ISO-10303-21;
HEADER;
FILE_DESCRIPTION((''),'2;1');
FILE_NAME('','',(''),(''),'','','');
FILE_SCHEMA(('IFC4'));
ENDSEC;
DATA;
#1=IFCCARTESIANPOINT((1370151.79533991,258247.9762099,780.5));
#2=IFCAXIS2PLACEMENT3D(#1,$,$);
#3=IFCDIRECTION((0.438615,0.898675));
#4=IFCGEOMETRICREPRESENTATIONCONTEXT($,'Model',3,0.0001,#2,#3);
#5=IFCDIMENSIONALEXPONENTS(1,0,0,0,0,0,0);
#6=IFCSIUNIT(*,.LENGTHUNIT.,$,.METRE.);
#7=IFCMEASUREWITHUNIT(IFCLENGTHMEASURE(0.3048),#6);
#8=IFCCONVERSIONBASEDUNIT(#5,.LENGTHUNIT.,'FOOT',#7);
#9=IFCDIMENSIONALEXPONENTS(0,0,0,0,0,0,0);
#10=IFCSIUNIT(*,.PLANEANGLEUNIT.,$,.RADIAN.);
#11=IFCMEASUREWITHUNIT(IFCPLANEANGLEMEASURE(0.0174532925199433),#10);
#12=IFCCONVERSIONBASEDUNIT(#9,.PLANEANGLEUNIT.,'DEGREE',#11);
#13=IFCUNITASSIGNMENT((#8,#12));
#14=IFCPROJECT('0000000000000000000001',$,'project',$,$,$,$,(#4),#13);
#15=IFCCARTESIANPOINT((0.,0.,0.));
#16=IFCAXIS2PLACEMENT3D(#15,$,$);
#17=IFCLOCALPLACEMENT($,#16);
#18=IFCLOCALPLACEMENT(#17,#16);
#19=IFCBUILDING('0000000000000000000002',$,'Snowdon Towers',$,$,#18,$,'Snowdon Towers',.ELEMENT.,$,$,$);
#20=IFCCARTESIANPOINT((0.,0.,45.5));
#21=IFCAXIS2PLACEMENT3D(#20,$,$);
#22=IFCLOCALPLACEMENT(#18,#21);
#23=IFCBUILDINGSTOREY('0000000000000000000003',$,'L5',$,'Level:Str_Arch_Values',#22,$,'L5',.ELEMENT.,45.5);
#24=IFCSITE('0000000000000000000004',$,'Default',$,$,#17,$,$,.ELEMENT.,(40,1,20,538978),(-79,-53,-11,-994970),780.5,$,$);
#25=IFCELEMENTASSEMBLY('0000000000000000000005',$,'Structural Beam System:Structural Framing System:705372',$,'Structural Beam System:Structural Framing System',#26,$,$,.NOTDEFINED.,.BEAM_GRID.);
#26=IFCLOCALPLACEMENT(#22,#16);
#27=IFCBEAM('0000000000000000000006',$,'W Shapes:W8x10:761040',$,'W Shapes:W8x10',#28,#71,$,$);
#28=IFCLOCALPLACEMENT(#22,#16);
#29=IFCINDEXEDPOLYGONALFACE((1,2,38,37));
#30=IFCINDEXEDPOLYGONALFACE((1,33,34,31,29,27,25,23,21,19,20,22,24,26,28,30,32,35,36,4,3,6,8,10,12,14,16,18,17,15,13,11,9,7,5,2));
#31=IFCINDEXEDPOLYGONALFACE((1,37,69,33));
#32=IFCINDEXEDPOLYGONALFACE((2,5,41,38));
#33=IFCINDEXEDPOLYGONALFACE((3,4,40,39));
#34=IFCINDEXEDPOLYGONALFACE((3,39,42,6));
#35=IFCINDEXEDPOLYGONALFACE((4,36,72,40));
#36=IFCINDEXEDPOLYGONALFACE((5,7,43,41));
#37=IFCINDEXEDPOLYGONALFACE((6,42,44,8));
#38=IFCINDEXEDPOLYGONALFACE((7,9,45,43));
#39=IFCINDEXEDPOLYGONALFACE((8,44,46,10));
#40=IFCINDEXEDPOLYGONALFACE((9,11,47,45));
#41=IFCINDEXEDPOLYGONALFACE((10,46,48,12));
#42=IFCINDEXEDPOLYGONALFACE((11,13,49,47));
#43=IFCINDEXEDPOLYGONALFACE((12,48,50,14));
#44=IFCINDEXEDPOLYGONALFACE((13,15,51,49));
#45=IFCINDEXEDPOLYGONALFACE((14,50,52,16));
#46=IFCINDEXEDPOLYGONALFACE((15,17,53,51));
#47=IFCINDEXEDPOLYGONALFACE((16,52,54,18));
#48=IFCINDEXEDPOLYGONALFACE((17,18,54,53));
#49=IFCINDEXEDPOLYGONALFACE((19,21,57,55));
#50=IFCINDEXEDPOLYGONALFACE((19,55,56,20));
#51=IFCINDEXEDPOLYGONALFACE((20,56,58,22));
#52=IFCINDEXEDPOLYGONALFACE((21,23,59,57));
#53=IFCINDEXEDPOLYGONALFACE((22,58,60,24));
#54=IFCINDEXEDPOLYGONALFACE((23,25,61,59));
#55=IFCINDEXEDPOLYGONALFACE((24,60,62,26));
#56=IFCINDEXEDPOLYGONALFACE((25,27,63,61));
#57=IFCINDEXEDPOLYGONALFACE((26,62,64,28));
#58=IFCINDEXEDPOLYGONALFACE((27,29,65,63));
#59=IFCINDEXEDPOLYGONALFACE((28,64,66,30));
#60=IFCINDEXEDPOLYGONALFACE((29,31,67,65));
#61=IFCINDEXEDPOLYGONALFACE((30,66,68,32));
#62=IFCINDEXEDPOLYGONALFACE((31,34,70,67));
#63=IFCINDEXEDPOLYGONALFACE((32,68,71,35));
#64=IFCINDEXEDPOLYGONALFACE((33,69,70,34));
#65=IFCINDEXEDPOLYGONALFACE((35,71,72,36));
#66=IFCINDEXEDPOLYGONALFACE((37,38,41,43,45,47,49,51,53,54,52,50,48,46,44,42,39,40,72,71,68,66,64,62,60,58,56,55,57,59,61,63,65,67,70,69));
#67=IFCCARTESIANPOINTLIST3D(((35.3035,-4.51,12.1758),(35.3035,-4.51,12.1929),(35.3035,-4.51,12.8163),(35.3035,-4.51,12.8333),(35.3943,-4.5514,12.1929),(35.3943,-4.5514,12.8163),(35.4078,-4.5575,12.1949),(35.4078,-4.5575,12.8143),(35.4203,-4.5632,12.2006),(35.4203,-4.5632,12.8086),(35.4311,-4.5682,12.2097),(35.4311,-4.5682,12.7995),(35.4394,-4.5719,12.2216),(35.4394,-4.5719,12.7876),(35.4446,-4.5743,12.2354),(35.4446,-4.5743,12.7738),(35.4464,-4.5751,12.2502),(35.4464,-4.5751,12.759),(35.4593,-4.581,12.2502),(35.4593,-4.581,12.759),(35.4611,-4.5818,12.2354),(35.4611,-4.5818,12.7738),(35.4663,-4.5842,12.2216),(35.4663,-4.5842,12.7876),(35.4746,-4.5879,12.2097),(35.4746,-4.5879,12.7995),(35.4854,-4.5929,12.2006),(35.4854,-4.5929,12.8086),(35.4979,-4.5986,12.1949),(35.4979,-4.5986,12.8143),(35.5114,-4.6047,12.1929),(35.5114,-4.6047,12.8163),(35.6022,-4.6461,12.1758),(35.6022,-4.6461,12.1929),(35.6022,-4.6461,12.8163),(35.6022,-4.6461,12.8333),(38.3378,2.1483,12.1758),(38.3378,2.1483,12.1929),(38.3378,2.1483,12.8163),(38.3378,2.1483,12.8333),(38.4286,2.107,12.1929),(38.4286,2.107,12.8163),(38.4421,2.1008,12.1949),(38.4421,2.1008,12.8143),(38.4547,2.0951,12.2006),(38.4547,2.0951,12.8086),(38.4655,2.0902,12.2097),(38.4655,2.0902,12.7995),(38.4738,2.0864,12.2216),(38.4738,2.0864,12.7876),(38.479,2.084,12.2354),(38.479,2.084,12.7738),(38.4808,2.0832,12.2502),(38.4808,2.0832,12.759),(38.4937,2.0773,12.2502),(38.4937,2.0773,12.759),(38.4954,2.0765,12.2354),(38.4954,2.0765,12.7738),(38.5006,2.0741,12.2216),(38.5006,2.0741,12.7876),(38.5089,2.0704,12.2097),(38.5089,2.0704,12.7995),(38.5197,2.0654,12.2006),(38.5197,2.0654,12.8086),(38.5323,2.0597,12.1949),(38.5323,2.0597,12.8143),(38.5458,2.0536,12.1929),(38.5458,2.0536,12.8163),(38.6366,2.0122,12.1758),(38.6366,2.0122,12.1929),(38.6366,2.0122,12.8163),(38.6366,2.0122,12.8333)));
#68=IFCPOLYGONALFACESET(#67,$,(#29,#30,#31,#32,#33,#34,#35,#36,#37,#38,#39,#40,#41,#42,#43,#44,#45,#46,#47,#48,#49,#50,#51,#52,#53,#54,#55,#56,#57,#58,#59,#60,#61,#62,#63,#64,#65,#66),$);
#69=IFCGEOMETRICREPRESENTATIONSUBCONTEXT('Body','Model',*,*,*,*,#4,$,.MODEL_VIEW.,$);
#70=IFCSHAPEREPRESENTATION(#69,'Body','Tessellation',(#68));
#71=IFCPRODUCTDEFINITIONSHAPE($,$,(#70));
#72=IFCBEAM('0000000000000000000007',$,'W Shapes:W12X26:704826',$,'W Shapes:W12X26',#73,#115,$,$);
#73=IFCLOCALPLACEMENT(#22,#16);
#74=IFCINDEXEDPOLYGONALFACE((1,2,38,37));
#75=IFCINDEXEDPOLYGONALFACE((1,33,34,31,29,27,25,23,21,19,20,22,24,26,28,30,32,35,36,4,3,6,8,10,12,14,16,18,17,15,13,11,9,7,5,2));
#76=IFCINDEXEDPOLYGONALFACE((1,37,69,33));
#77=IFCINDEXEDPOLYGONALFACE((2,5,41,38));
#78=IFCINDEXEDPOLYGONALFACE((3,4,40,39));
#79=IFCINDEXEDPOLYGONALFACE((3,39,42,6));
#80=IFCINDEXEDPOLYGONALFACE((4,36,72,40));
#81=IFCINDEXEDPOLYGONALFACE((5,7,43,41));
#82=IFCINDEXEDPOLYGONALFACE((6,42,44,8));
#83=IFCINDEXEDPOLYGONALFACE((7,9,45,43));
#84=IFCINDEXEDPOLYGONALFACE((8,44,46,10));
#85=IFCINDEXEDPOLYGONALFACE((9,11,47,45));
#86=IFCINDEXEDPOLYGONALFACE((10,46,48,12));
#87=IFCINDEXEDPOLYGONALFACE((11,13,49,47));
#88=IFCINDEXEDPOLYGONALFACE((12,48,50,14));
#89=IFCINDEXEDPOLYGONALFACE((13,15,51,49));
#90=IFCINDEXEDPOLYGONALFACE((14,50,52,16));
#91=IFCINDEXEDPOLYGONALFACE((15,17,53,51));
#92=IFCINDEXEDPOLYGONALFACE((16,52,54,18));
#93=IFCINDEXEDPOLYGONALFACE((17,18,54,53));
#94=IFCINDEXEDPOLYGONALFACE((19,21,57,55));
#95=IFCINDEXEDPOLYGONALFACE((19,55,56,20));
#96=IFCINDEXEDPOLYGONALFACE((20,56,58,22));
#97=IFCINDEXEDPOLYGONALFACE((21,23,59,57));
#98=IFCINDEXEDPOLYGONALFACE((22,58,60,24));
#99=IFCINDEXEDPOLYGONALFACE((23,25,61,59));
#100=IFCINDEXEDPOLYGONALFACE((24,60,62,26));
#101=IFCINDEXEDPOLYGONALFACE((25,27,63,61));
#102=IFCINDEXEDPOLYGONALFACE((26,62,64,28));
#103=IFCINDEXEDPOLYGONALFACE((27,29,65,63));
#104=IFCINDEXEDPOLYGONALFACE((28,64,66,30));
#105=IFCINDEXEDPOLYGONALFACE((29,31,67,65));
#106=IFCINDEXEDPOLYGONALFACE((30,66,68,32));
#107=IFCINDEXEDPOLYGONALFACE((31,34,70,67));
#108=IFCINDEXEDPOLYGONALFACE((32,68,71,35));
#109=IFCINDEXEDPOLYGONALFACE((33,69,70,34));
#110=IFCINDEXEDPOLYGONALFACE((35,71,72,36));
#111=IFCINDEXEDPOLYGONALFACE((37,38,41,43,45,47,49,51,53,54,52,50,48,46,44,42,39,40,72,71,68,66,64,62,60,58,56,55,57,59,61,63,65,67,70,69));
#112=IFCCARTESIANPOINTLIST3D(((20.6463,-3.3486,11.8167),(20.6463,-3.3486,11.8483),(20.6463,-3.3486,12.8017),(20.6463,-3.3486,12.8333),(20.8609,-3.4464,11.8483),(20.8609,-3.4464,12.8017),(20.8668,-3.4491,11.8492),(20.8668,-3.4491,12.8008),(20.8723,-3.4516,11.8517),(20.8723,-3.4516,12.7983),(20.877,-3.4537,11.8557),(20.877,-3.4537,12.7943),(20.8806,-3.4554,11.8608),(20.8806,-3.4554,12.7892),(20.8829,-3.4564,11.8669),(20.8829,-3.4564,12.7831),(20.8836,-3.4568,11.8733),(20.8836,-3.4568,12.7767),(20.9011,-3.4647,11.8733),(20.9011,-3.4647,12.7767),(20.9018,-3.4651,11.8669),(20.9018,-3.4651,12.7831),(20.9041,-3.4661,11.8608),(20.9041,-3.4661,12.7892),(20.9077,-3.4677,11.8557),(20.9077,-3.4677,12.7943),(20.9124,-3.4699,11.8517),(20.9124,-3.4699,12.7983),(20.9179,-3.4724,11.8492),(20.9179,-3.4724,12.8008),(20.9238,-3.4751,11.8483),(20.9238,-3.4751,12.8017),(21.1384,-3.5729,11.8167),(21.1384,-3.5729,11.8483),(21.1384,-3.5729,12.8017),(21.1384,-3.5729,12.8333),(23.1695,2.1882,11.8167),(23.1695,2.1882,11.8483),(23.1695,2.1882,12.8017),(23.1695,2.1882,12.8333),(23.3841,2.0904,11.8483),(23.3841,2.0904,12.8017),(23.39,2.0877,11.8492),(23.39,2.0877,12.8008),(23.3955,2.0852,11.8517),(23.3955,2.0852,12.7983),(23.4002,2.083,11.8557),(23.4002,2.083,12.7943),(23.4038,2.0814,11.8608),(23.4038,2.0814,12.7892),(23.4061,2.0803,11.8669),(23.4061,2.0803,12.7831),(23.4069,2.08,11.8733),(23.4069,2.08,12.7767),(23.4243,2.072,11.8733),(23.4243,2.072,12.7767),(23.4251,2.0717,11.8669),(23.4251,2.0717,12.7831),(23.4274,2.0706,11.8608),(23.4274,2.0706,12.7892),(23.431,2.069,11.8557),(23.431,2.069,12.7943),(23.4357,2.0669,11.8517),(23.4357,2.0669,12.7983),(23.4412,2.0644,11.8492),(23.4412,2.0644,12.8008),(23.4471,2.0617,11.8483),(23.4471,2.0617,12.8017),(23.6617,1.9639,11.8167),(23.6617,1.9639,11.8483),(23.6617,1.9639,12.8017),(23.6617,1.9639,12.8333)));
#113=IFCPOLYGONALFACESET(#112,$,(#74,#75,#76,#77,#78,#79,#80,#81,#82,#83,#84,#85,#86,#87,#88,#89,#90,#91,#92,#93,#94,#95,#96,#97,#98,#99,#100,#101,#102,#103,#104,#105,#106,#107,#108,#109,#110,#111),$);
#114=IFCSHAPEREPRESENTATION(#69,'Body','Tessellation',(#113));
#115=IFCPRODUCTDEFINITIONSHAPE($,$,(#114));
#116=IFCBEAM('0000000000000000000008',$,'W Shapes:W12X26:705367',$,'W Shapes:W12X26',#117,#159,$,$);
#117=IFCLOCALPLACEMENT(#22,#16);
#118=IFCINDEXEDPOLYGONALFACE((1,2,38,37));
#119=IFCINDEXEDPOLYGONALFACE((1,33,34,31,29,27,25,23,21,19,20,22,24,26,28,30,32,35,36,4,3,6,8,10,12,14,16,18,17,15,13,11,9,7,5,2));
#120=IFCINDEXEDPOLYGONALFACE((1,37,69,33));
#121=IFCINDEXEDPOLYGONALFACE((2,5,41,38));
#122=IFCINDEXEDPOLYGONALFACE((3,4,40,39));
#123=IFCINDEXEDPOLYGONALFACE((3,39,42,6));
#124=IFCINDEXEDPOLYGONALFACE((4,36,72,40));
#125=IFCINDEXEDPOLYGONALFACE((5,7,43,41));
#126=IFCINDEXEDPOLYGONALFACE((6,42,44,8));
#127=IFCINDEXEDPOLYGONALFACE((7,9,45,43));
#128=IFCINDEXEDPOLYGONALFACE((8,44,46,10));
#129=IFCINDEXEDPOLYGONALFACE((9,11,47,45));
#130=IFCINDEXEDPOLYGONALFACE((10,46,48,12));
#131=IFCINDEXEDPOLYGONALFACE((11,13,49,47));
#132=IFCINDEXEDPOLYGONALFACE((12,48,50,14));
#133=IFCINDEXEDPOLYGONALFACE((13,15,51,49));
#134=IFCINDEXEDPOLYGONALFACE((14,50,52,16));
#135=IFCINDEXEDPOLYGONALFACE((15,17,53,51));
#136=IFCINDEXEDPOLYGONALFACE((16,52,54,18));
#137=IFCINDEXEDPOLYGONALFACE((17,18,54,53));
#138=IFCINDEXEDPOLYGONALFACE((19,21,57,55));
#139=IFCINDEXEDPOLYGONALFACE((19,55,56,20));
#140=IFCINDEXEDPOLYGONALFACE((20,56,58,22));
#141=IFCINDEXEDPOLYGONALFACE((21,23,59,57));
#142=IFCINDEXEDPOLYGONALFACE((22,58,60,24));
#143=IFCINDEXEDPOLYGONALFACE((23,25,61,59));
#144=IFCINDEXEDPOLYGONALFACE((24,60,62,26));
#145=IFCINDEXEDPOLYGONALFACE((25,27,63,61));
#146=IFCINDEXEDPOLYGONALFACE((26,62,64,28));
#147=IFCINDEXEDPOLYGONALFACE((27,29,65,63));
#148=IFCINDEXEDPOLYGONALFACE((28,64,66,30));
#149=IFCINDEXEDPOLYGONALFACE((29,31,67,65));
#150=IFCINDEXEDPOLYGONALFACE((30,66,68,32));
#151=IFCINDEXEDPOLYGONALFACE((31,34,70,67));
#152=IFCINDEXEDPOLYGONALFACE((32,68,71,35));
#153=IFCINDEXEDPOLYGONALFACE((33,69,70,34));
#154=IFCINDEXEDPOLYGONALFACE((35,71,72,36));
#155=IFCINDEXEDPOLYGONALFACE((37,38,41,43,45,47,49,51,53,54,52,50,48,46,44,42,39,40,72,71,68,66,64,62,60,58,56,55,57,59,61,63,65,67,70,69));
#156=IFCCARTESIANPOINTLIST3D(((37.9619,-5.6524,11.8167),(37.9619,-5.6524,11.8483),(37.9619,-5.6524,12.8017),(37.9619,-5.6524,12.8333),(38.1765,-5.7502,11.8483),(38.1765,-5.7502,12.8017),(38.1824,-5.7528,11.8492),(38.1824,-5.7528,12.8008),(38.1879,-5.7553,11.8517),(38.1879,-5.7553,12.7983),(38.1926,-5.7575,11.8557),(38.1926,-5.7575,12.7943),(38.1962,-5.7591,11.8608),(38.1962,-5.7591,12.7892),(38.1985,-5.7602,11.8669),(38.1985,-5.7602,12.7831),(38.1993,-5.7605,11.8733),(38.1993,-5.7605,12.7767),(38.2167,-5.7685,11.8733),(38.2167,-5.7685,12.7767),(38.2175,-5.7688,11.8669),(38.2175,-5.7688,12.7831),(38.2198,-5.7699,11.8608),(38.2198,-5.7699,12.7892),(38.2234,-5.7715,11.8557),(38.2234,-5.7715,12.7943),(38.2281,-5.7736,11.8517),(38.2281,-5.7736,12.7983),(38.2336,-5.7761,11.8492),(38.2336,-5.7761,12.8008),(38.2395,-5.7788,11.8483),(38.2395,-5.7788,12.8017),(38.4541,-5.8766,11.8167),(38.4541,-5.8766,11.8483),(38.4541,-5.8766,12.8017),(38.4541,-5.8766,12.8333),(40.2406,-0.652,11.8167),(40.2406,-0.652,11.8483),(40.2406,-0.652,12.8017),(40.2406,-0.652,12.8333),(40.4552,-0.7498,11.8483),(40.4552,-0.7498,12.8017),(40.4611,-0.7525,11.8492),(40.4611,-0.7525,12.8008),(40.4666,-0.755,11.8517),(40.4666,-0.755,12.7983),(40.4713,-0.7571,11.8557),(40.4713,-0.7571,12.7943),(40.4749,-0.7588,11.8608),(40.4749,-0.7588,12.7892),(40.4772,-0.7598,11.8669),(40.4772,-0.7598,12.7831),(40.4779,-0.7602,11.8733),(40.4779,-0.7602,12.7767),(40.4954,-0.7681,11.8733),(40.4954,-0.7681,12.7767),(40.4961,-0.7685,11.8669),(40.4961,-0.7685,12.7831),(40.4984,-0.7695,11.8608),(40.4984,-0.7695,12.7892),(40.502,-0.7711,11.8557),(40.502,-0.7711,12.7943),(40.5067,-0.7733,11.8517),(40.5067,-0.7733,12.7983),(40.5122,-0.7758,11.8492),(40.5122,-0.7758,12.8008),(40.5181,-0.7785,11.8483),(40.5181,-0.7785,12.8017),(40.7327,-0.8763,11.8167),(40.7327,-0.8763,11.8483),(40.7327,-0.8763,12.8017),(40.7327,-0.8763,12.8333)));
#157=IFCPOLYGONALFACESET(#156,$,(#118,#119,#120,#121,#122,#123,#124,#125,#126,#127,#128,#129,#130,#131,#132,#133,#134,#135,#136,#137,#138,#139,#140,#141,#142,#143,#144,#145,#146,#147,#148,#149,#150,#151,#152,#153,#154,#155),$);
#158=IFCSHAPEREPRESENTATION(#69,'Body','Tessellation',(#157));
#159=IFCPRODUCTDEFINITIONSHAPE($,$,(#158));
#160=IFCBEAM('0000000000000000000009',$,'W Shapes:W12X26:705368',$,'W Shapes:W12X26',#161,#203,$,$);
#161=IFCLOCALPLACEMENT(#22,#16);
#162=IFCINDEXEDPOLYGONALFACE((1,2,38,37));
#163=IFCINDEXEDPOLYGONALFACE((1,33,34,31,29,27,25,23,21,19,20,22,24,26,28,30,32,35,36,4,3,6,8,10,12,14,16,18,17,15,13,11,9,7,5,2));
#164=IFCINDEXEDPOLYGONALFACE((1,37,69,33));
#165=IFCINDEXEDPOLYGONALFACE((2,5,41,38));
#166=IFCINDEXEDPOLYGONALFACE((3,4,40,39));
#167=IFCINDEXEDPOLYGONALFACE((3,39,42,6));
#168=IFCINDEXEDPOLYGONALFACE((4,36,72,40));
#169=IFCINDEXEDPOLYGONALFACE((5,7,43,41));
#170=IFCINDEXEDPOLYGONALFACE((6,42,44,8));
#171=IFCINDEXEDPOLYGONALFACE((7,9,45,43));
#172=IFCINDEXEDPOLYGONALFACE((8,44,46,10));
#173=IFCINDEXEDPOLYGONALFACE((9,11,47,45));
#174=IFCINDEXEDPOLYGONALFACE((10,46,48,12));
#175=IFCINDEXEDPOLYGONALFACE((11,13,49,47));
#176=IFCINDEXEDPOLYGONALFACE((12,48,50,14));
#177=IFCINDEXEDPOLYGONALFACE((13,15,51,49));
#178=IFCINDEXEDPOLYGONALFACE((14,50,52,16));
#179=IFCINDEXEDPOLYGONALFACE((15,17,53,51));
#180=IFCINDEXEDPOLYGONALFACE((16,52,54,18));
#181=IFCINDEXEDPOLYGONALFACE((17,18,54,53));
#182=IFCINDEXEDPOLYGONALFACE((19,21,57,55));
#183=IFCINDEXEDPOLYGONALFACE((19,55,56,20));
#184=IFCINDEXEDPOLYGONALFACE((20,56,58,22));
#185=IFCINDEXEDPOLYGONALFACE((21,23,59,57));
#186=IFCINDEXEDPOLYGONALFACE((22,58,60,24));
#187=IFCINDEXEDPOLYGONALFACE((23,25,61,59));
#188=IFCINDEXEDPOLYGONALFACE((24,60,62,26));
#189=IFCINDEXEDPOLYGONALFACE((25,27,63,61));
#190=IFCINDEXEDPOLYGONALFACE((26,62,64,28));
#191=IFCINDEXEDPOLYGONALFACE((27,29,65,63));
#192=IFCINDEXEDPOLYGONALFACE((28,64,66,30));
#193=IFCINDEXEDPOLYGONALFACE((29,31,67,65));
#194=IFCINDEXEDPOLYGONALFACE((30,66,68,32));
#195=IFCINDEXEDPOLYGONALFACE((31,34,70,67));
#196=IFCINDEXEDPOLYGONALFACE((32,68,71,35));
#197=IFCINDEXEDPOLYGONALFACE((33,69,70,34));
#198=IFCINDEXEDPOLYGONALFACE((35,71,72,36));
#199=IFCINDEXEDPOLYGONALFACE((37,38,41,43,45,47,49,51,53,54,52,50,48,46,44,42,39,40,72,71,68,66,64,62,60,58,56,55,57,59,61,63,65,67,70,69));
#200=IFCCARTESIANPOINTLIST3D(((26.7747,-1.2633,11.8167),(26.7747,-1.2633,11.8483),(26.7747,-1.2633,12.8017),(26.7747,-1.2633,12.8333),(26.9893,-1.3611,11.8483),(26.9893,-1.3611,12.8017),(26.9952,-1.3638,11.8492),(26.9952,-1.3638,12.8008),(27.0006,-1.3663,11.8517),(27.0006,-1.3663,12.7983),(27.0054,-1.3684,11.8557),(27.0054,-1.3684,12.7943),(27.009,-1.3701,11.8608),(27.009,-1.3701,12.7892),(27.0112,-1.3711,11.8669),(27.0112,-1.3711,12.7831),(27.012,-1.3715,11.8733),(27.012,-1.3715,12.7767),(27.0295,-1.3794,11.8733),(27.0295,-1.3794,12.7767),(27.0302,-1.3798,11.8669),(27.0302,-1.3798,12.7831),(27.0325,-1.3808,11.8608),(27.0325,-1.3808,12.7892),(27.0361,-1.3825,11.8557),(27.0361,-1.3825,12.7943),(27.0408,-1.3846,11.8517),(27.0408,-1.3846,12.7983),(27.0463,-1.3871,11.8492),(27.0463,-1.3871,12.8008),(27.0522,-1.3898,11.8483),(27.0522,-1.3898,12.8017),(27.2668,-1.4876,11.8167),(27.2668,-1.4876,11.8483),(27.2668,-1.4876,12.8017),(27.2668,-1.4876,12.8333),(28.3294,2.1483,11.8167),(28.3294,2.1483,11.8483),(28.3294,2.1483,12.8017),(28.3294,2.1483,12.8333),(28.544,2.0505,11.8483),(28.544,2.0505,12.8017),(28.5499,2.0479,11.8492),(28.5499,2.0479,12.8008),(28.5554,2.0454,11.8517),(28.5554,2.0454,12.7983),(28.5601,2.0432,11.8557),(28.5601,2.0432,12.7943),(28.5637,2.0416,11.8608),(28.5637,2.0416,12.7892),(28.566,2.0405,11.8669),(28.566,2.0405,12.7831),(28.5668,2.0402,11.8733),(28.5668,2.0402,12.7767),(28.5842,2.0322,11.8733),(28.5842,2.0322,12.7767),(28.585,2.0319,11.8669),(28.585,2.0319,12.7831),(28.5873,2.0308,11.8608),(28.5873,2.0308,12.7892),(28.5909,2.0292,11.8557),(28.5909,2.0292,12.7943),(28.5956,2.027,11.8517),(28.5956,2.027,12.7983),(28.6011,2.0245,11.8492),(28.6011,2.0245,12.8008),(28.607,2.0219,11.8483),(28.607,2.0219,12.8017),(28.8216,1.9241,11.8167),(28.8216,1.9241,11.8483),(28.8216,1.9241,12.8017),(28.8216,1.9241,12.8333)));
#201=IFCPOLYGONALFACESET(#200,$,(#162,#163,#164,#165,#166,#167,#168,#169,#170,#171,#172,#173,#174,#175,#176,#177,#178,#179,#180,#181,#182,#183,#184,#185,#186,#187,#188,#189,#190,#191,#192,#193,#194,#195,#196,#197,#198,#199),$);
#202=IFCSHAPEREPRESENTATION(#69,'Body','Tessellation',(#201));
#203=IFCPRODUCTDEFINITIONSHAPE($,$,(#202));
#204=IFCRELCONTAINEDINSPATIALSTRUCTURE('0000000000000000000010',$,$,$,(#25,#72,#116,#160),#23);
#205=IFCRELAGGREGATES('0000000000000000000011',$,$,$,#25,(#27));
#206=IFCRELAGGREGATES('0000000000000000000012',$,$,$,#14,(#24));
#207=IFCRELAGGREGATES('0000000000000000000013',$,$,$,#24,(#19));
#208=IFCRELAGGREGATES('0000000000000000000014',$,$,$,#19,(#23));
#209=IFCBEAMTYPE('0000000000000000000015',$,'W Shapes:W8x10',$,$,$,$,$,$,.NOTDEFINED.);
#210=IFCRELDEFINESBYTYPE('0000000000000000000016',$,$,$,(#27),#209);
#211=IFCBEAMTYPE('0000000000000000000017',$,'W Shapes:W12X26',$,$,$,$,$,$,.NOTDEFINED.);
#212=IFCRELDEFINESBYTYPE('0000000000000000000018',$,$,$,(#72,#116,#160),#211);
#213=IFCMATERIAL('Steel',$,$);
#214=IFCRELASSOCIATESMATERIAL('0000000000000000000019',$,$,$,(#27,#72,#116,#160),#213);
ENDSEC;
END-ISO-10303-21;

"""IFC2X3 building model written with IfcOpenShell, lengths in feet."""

from ifc_helpers import new_model, entity, si_unit, converted_unit, direction, frame, frame_2d, origin, place, context, subcontext, project, spatial, i_section, extrude, material, type_object, element, aggregate, save


model = new_model("IFC2X3")

# Units and contexts
model_context = context("Model", 3, precision=0.0001, world=frame((1370151.79533991, 258247.9762099, 780.5)), true_north=direction((0.438615, 0.898675)))
body_context = subcontext(model_context, "Body", "Model", "MODEL_VIEW")
ifc_project = project(units=[converted_unit("LENGTHUNIT", "FOOT", entity("IfcLengthMeasure", 0.3048), si_unit("LENGTHUNIT", "METRE"), dimensions=[1, 0, 0, 0, 0, 0, 0]), converted_unit("PLANEANGLEUNIT", "DEGREE", entity("IfcPlaneAngleMeasure", 0.0174532925199433), si_unit("PLANEANGLEUNIT", "RADIAN"), dimensions=[0, 0, 0, 0, 0, 0, 0])], contexts=[model_context])

# Site, building, storey
site_placement = place(None, origin())
site = spatial("IfcSite", under=ifc_project, at=site_placement, Name="Default", CompositionType="ELEMENT", RefLatitude=(40, 1, 20, 538978), RefLongitude=(-79, -53, -11, -994970), RefElevation=780.5)
building_placement = place(site_placement, origin())
building = spatial("IfcBuilding", under=site, at=building_placement, Name="Snowdon Towers", LongName="Snowdon Towers", CompositionType="ELEMENT")
storey_placement = place(building_placement, frame((0.0, 0.0, 45.5)))
storey = spatial("IfcBuildingStorey", under=building, at=storey_placement, Name="L5", ObjectType="Level:Str_Arch_Values", LongName="L5", CompositionType="ELEMENT", Elevation=45.5)

# Shared definitions
ifc_material = material(Name="Steel")

# Shared definitions
beam_type_1 = type_object("IfcBeamType", Name="W Shapes:W8x10", PredefinedType="NOTDEFINED")

# Element assembly
assembly_1_placement = place(storey_placement, origin())
assembly_1 = element("IfcElementAssembly", 1, at=assembly_1_placement, inside=storey, Name="Structural Beam System:Structural Framing System:705372", ObjectType="Structural Beam System:Structural Framing System", AssemblyPlace="NOTDEFINED", PredefinedType="BEAM_GRID")

# Beam
beam_1_placement = place(assembly_1_placement, frame((35.3234, -4.862, 12.8333), z_axis=(0.0, 0.0, 1.0), x_axis=(0.414693, 0.909961, 0.0)))
beam_1 = element("IfcBeam", 2, at=beam_1_placement, type_object=beam_type_1, material=ifc_material, Name="W Shapes:W8x10:761040", ObjectType="W Shapes:W8x10", context=body_context, shape_type="SweptSolid", body=[
    extrude(i_section(OverallWidth=0.3283, OverallDepth=0.6575, WebThickness=0.0142, FlangeThickness=0.0171, FilletRadius=0.0573, at=frame_2d((0.0, 0.0), x_axis=(0.0, 1.0))), frame((0.3121, 0.0, -0.3288), z_axis=(1.0, 0.0, 0.0), x_axis=(0.0, 0.0, -1.0)), (0.0, 0.0, 1.0), 7.3171),
])
aggregate(assembly_1, [beam_1])

# Beams
beam_type_2 = type_object("IfcBeamType", Name="W Shapes:W12X26", PredefinedType="NOTDEFINED")
beam_2_placement = place(storey_placement, frame((20.7368, -3.802, 12.8333), z_axis=(0.0, 0.0, 1.0), x_axis=(0.414693, 0.909961, 0.0)))
element("IfcBeam", 3, at=beam_2_placement, inside=storey, type_object=beam_type_2, material=ifc_material, Name="W Shapes:W12X26:704826", ObjectType="W Shapes:W12X26", context=body_context, shape_type="SweptSolid", body=[
    extrude(i_section(OverallWidth=0.5408, OverallDepth=1.0167, WebThickness=0.0192, FlangeThickness=0.0317, FilletRadius=0.025, at=frame_2d((0.0, 0.0), x_axis=(0.0, 1.0))), frame((0.375, 0.0, -0.5083), z_axis=(1.0, 0.0, 0.0), x_axis=(0.0, 0.0, -1.0)), (0.0, 0.0, 1.0), 6.0846),
])
beam_3_placement = place(storey_placement, frame((38.0525, -6.1057, 12.8333), z_axis=(0.0, 0.0, 1.0), x_axis=(0.414671, 0.909972, 0.0)))
element("IfcBeam", 4, at=beam_3_placement, inside=storey, type_object=beam_type_2, material=ifc_material, Name="W Shapes:W12X26:705367", ObjectType="W Shapes:W12X26", context=body_context, shape_type="SweptSolid", body=[
    extrude(i_section(OverallWidth=0.5408, OverallDepth=1.0167, WebThickness=0.0192, FlangeThickness=0.0317, FilletRadius=0.025, at=frame_2d((0.0, 0.0), x_axis=(0.0, 1.0))), frame((0.375, 0.0, -0.5083), z_axis=(1.0, 0.0, 0.0), x_axis=(0.0, 0.0, -1.0)), (0.0, 0.0, 1.0), 5.4951),
])
beam_4_placement = place(storey_placement, frame((27.1329, -1.1294, 12.8333), z_axis=(0.0, 0.0, 1.0), x_axis=(0.414693, 0.909961, 0.0)))
element("IfcBeam", 5, at=beam_4_placement, inside=storey, type_object=beam_type_2, material=ifc_material, Name="W Shapes:W12X26:705368", ObjectType="W Shapes:W12X26", context=body_context, shape_type="SweptSolid", body=[
    extrude(i_section(OverallWidth=0.5408, OverallDepth=1.0167, WebThickness=0.0192, FlangeThickness=0.0317, FilletRadius=0.025, at=frame_2d((0.0, 0.0), x_axis=(0.0, 1.0))), frame((-0.2704, 0.0, -0.5083), z_axis=(1.0, 0.0, 0.0), x_axis=(0.0, 0.0, -1.0)), (0.0, 0.0, 1.0), 3.7492),
])

save(model, "model.ifc")
